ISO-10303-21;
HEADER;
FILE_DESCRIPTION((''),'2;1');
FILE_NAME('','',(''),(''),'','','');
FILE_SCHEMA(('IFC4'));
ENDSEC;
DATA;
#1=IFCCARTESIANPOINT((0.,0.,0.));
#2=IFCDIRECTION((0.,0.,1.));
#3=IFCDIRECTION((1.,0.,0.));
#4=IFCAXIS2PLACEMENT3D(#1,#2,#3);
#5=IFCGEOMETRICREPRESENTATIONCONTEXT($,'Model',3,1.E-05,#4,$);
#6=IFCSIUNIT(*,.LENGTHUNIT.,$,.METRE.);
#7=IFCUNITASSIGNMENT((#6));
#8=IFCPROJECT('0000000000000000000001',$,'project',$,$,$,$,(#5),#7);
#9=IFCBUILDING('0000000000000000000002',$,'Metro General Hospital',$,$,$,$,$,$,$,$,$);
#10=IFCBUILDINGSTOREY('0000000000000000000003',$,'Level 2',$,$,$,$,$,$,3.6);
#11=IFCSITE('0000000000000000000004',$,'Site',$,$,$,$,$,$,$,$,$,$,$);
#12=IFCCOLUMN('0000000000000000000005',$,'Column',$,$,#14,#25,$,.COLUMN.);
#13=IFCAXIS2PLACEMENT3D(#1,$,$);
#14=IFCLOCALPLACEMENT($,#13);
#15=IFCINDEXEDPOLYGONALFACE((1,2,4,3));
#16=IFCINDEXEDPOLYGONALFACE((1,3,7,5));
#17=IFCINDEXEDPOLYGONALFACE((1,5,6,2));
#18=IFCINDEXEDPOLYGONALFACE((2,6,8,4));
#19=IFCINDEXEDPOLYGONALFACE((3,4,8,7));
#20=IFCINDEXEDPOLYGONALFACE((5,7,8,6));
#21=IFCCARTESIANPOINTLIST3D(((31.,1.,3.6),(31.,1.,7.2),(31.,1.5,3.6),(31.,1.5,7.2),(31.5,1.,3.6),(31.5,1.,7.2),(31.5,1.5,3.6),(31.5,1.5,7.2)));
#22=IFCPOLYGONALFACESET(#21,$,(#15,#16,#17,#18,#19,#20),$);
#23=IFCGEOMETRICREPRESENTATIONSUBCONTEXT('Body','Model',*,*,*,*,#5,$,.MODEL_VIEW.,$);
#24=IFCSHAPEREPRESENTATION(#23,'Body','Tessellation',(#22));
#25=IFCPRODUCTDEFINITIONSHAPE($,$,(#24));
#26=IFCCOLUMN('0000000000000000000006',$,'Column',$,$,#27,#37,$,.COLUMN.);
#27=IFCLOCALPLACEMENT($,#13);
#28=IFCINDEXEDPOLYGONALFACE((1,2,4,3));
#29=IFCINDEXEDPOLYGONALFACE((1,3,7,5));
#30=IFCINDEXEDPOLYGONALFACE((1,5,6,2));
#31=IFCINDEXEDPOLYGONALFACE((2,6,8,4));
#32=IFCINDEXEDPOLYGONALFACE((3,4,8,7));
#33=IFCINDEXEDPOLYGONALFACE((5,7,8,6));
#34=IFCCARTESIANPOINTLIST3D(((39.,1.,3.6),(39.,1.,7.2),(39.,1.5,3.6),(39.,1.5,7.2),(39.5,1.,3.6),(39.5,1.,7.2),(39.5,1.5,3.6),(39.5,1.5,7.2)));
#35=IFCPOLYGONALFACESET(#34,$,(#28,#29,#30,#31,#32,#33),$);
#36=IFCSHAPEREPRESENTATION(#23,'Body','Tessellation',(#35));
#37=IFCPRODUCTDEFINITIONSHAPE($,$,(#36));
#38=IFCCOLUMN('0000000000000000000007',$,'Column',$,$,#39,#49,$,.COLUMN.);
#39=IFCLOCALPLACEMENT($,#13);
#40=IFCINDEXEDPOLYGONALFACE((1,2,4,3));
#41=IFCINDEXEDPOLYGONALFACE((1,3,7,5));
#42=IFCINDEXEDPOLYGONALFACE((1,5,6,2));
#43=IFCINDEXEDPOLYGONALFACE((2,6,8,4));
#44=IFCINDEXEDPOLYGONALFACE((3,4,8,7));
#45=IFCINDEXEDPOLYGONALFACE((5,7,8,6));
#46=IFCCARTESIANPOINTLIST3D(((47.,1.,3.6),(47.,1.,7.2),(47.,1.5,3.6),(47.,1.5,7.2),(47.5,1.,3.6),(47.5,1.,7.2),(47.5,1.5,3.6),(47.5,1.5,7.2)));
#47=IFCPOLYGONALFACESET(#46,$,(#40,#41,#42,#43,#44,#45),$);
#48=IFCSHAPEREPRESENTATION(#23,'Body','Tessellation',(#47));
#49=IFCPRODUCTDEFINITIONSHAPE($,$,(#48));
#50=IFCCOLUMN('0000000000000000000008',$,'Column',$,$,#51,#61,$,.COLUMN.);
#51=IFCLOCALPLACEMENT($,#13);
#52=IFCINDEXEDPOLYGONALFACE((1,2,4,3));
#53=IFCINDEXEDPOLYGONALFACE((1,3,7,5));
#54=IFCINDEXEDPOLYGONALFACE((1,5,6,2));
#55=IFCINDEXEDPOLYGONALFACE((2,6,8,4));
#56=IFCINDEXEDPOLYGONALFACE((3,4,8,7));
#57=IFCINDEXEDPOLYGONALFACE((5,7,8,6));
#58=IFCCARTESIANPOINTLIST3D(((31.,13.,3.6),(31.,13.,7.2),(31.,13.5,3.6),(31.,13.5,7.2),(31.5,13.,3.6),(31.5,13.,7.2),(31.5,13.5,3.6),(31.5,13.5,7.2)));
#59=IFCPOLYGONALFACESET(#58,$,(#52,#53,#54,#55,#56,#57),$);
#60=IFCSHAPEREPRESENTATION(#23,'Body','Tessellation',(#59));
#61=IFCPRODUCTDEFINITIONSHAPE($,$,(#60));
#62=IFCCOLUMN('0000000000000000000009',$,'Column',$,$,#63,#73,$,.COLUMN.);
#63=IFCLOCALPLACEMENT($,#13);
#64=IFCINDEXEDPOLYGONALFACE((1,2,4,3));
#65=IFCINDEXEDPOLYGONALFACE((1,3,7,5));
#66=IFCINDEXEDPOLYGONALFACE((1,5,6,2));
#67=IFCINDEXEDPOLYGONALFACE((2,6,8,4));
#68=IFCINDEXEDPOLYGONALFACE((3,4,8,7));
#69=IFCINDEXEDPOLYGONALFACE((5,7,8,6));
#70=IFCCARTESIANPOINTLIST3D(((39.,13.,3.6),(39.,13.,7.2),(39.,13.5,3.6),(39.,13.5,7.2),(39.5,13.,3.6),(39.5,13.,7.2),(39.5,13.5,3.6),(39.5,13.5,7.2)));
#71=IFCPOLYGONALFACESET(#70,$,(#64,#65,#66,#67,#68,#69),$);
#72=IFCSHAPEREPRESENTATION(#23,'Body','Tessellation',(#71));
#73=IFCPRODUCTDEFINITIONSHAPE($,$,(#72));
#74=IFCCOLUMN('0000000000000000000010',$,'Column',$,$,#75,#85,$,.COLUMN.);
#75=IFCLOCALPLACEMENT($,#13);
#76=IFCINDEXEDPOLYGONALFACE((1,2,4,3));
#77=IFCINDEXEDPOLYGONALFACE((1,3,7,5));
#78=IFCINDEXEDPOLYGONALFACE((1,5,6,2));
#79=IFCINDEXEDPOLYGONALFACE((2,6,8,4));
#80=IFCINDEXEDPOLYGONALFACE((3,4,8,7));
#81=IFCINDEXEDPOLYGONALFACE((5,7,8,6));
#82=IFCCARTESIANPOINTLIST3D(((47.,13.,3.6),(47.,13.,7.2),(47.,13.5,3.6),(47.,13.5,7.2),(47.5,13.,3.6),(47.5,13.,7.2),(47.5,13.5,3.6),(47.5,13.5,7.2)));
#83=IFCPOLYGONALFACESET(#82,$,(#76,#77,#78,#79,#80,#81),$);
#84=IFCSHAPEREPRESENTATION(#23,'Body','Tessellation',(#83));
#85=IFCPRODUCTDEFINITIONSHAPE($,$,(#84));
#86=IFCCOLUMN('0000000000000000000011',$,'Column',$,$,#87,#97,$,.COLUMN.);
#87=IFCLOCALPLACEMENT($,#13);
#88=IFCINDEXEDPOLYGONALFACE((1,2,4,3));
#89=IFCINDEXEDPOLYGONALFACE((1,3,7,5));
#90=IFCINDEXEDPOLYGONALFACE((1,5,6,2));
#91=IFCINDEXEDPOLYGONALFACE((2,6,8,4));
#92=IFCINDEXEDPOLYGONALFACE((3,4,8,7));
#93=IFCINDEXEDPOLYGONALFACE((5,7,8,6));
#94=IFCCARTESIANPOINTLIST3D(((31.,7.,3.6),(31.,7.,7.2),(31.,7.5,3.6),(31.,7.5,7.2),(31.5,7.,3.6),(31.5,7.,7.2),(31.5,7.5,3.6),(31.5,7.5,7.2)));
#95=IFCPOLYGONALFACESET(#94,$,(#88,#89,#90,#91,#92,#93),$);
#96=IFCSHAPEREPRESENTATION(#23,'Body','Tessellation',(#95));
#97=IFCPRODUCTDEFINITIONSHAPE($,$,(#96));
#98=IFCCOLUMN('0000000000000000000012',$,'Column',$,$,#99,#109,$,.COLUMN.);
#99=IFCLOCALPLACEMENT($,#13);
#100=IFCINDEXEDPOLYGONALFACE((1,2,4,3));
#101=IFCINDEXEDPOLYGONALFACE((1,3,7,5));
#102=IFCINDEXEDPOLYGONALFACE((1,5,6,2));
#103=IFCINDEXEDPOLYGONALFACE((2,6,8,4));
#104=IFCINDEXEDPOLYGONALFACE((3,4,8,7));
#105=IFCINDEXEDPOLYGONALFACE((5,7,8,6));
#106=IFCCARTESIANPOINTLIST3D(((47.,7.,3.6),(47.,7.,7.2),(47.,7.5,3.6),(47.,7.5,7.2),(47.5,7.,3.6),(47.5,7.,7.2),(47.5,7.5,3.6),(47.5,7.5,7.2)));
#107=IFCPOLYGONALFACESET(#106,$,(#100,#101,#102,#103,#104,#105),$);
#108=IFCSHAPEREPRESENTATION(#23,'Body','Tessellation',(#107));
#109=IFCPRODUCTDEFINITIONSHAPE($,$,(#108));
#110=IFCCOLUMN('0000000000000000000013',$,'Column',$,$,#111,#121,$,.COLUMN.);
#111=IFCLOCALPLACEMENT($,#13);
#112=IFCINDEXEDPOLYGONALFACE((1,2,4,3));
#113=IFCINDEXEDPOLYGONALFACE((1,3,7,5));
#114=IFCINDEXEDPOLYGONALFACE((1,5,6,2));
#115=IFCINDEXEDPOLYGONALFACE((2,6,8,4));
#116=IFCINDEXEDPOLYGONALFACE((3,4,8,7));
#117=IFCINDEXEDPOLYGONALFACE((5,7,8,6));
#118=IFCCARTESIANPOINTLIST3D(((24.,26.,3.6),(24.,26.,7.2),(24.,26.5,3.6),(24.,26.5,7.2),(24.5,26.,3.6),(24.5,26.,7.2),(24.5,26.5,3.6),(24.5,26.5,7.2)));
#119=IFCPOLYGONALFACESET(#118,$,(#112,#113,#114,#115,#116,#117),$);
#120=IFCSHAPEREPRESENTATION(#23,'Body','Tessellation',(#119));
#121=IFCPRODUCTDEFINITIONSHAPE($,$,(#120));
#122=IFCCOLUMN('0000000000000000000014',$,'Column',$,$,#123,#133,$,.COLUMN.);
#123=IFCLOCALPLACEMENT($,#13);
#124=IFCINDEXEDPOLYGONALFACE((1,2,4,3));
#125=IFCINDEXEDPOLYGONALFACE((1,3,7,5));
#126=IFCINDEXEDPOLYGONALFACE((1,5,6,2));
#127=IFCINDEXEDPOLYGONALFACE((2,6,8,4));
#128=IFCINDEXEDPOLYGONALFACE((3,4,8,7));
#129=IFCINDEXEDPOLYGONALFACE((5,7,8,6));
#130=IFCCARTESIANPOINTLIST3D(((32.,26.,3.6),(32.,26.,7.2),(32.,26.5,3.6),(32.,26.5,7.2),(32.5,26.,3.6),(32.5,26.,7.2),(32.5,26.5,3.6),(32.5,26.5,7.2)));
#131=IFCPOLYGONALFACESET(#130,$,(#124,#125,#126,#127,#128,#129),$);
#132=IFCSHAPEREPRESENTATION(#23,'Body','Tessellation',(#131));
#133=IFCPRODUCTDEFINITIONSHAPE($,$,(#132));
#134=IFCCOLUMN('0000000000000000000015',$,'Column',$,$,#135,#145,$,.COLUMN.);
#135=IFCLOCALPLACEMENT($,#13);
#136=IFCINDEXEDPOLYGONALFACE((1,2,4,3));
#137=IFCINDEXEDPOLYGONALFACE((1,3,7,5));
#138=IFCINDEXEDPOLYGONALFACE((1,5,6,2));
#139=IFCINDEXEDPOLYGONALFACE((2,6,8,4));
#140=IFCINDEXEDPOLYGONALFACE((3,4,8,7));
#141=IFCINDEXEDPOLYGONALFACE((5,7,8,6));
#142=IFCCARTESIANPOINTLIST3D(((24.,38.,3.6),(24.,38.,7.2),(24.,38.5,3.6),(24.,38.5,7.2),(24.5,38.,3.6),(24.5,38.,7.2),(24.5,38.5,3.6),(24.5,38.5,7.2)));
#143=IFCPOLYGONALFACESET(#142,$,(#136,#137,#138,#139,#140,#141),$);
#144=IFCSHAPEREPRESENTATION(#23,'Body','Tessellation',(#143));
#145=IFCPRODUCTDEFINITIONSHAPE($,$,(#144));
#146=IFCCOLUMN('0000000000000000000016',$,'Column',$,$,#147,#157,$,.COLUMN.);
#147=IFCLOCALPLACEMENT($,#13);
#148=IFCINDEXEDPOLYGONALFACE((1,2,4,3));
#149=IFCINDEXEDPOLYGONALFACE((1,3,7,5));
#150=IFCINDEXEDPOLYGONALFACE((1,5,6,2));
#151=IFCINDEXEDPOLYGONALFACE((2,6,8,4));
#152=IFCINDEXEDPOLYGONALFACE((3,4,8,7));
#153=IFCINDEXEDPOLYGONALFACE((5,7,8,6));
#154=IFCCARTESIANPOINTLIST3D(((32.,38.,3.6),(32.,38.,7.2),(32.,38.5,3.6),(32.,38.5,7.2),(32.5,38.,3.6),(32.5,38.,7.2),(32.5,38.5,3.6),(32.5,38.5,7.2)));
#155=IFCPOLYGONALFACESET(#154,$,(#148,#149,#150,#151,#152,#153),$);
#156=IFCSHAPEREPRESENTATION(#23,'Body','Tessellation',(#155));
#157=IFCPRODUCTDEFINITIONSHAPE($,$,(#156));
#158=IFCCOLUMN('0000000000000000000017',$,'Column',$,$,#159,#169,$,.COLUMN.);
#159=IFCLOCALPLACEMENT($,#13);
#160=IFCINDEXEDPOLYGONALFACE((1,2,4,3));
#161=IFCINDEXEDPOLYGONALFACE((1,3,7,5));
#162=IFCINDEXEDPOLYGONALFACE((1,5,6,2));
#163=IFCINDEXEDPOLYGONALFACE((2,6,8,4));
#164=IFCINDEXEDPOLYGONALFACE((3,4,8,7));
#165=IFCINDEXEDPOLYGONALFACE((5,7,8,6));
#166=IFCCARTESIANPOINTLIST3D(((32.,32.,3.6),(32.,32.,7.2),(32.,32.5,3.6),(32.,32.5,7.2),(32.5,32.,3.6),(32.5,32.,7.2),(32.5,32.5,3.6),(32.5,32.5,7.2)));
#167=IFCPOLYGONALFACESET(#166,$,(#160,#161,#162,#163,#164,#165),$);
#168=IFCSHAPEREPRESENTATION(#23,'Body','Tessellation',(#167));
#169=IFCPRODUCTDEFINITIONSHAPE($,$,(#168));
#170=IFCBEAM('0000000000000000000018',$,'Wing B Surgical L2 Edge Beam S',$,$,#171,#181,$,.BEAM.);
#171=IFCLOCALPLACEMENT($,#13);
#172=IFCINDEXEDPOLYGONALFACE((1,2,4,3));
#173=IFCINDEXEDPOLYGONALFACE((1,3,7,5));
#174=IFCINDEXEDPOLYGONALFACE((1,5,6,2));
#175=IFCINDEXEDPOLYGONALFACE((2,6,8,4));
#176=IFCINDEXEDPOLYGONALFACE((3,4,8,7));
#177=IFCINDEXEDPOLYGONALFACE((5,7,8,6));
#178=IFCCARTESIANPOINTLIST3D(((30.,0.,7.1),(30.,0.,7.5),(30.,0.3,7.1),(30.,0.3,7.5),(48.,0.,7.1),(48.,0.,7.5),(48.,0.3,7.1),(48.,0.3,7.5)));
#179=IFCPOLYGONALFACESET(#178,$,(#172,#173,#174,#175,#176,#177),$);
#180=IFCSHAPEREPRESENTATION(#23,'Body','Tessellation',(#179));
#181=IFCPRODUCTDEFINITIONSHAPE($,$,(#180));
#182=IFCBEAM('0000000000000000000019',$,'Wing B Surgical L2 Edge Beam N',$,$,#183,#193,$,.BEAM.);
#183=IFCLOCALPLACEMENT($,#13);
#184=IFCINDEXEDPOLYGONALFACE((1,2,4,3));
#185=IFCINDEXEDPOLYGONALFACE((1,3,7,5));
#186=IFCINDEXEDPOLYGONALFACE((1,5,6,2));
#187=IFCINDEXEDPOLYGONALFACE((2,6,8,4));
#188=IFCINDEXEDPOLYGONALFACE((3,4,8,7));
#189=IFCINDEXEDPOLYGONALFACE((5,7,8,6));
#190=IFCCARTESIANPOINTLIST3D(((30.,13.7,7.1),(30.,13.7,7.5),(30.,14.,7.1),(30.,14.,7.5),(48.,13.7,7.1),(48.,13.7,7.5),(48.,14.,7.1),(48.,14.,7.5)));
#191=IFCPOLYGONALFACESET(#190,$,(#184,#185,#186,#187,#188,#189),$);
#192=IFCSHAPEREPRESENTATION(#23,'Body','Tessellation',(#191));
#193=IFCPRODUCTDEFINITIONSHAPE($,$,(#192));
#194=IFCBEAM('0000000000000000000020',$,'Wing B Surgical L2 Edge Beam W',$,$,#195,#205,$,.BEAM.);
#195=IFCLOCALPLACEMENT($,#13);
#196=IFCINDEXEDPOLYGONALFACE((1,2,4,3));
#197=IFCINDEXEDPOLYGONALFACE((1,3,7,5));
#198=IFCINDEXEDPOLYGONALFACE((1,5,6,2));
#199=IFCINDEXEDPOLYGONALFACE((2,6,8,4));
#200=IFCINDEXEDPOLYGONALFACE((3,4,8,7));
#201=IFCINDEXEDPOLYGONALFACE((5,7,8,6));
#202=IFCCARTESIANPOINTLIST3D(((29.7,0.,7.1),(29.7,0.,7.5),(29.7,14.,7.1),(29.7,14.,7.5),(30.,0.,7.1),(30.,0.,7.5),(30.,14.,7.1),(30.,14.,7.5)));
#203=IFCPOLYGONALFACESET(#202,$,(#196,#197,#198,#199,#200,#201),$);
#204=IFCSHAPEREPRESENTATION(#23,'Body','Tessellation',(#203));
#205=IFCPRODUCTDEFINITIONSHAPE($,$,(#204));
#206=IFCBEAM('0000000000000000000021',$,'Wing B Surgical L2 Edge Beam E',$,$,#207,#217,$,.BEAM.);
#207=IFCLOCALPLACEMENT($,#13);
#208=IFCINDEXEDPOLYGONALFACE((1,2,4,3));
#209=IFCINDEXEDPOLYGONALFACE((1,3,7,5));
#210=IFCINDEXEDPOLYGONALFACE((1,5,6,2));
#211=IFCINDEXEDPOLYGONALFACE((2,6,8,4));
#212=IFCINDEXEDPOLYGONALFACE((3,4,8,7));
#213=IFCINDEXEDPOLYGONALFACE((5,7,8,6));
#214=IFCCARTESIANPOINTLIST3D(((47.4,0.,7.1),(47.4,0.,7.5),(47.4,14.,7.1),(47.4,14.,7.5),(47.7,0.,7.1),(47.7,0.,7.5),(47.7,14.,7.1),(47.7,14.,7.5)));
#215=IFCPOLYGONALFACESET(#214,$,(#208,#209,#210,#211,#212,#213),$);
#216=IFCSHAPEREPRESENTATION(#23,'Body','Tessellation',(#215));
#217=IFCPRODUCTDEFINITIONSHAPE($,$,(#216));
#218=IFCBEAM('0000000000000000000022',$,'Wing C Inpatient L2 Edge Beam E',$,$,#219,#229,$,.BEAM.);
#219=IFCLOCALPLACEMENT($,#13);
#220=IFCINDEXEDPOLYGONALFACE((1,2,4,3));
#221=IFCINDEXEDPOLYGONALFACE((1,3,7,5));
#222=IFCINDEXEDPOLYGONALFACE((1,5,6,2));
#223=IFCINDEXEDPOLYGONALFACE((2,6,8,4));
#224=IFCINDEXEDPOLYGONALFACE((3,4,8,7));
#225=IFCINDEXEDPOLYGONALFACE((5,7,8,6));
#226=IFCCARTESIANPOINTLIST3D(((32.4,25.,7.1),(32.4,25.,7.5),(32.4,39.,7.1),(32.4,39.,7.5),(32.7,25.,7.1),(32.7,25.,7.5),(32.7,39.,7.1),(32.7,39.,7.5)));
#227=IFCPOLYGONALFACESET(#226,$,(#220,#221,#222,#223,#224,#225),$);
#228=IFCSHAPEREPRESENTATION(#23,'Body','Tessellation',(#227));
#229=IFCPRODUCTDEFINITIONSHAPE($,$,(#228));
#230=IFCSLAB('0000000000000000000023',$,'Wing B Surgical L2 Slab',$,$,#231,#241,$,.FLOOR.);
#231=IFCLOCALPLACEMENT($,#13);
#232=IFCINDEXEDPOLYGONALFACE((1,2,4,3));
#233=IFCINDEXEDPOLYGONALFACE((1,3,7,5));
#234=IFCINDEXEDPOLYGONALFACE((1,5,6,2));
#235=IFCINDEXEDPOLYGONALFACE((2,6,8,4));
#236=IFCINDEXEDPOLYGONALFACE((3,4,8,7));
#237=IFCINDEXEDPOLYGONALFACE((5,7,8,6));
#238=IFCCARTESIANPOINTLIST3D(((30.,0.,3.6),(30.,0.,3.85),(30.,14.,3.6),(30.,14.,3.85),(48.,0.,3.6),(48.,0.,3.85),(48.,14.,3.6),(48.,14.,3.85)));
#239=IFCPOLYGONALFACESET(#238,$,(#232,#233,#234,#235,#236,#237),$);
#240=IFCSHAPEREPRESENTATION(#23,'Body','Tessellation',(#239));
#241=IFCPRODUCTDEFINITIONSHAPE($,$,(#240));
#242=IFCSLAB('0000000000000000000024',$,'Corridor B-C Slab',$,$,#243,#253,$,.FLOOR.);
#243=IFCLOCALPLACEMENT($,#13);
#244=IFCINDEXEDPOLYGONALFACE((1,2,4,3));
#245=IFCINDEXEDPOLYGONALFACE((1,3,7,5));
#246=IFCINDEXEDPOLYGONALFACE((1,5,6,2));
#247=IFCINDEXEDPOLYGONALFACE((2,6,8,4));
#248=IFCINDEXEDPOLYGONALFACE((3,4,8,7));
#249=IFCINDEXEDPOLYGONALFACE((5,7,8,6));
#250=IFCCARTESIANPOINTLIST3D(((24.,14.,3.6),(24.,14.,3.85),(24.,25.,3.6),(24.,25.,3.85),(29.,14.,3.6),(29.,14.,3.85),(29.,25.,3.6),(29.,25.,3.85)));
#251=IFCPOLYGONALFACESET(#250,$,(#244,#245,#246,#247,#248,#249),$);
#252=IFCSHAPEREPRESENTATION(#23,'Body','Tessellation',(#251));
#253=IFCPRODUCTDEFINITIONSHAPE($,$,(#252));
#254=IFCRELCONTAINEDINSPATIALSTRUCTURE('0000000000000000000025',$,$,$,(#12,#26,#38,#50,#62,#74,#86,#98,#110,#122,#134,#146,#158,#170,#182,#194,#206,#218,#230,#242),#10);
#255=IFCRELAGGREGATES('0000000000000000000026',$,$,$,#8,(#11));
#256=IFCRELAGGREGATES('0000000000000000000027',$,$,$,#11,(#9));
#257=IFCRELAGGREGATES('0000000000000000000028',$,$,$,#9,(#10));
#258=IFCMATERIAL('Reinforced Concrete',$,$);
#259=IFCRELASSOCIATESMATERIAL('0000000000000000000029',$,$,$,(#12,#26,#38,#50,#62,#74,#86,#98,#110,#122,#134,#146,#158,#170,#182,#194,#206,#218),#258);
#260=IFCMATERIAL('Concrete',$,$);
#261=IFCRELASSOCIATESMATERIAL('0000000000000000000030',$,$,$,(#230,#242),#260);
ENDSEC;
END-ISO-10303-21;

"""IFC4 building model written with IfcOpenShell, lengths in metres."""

from ifc_helpers import new_model, si_unit, frame, origin_with_axes, place, context, subcontext, project, spatial, line, indexed_curve, outline, extrude, material, element, save


model = new_model("IFC4")

# Units and contexts
model_context = context("Model", 3, precision=1e-05, world=origin_with_axes())
body_context = subcontext(model_context, "Body", "Model", "MODEL_VIEW")
ifc_project = project(units=[si_unit("LENGTHUNIT", "METRE")], contexts=[model_context])

# Site, building, storey
site = spatial("IfcSite", under=ifc_project, Name="Site")
building = spatial("IfcBuilding", under=site, Name="Metro General Hospital")
storey = spatial("IfcBuildingStorey", under=building, Name="Level 2", Elevation=3.6)

# Columns
ifc_material_1 = material(Name="Reinforced Concrete")
for number, where, z_axis, x_axis, name in (
    (1, (31.0, 1.0, 3.6), (0.0, 0.0, 1.0), (1.0, 0.0, 0.0), "Column"),
    (2, (39.0, 1.0, 3.6), (0.0, 0.0, 1.0), (1.0, 0.0, 0.0), "Column"),
    (3, (47.0, 1.0, 3.6), (0.0, 0.0, 1.0), (1.0, 0.0, 0.0), "Column"),
    (4, (31.0, 13.0, 3.6), (0.0, 0.0, 1.0), (1.0, 0.0, 0.0), "Column"),
    (5, (39.0, 13.0, 3.6), (0.0, 0.0, 1.0), (1.0, 0.0, 0.0), "Column"),
    (6, (47.0, 13.0, 3.6), (0.0, 0.0, 1.0), (1.0, 0.0, 0.0), "Column"),
    (7, (31.0, 7.0, 3.6), (0.0, 0.0, 1.0), (1.0, 0.0, 0.0), "Column"),
    (8, (47.0, 7.0, 3.6), (0.0, 0.0, 1.0), (1.0, 0.0, 0.0), "Column"),
    (9, (24.0, 26.0, 3.6), (0.0, 0.0, 1.0), (1.0, 0.0, 0.0), "Column"),
    (10, (32.0, 26.0, 3.6), (0.0, 0.0, 1.0), (1.0, 0.0, 0.0), "Column"),
    (11, (24.0, 38.0, 3.6), (0.0, 0.0, 1.0), (1.0, 0.0, 0.0), "Column"),
    (12, (32.0, 38.0, 3.6), (0.0, 0.0, 1.0), (1.0, 0.0, 0.0), "Column"),
    (13, (32.0, 32.0, 3.6), (0.0, 0.0, 1.0), (1.0, 0.0, 0.0), "Column"),
):
    element("IfcColumn", number, at=place(None, frame(where, z_axis=z_axis, x_axis=x_axis)), inside=storey, material=ifc_material_1, Name=name, PredefinedType="COLUMN", context=body_context, shape_type="SweptSolid", body=[
        extrude(outline(indexed_curve([(0.0, 0.0), (0.5, 0.0), (0.5, 0.5), (0.0, 0.5)], segments=[line(1, 2, 3, 4, 1)])), origin_with_axes(), (0.0, 0.0, 1.0), 3.6),
    ])

# Beams
for number, where, z_axis, x_axis, name in (
    (14, (30.0, 0.0, 7.1), (0.0, 0.0, 1.0), (1.0, 0.0, 0.0), "Wing B Surgical L2 Edge Beam S"),
    (15, (30.0, 13.7, 7.1), (0.0, 0.0, 1.0), (1.0, 0.0, 0.0), "Wing B Surgical L2 Edge Beam N"),
):
    element("IfcBeam", number, at=place(None, frame(where, z_axis=z_axis, x_axis=x_axis)), inside=storey, material=ifc_material_1, Name=name, PredefinedType="BEAM", context=body_context, shape_type="SweptSolid", body=[
        extrude(outline(indexed_curve([(0.0, 0.0), (18.0, 0.0), (18.0, 0.3), (0.0, 0.3)], segments=[line(1, 2, 3, 4, 1)])), origin_with_axes(), (0.0, 0.0, 1.0), 0.4),
    ])
for number, where, z_axis, x_axis, name in (
    (16, (30.0, 0.0, 7.1), (0.0, 0.0, 1.0), (0.0, 1.0, 0.0), "Wing B Surgical L2 Edge Beam W"),
    (17, (47.7, 0.0, 7.1), (0.0, 0.0, 1.0), (0.0, 1.0, 0.0), "Wing B Surgical L2 Edge Beam E"),
    (18, (32.7, 25.0, 7.1), (0.0, 0.0, 1.0), (0.0, 1.0, 0.0), "Wing C Inpatient L2 Edge Beam E"),
):
    element("IfcBeam", number, at=place(None, frame(where, z_axis=z_axis, x_axis=x_axis)), inside=storey, material=ifc_material_1, Name=name, PredefinedType="BEAM", context=body_context, shape_type="SweptSolid", body=[
        extrude(outline(indexed_curve([(0.0, 0.0), (14.0, 0.0), (14.0, 0.3), (0.0, 0.3)], segments=[line(1, 2, 3, 4, 1)])), origin_with_axes(), (0.0, 0.0, 1.0), 0.4),
    ])

# Slabs
ifc_material_2 = material(Name="Concrete")
slab_1_placement = place(None, frame((30.0, 0.0, 3.6), z_axis=(0.0, 0.0, 1.0), x_axis=(1.0, 0.0, 0.0)))
element("IfcSlab", 19, at=slab_1_placement, inside=storey, material=ifc_material_2, Name="Wing B Surgical L2 Slab", PredefinedType="FLOOR", context=body_context, shape_type="SweptSolid", body=[
    extrude(outline(indexed_curve([(0.0, 0.0), (18.0, 0.0), (18.0, 14.0), (0.0, 14.0)], segments=[line(1, 2, 3, 4, 1)])), origin_with_axes(), (0.0, 0.0, 1.0), 0.25),
])
slab_2_placement = place(None, frame((24.0, 14.0, 3.6), z_axis=(0.0, 0.0, 1.0), x_axis=(1.0, 0.0, 0.0)))
element("IfcSlab", 20, at=slab_2_placement, inside=storey, material=ifc_material_2, Name="Corridor B-C Slab", PredefinedType="FLOOR", context=body_context, shape_type="SweptSolid", body=[
    extrude(outline(indexed_curve([(0.0, 0.0), (5.0, 0.0), (5.0, 11.0), (0.0, 11.0)], segments=[line(1, 2, 3, 4, 1)])), origin_with_axes(), (0.0, 0.0, 1.0), 0.25),
])

save(model, "model.ifc")
